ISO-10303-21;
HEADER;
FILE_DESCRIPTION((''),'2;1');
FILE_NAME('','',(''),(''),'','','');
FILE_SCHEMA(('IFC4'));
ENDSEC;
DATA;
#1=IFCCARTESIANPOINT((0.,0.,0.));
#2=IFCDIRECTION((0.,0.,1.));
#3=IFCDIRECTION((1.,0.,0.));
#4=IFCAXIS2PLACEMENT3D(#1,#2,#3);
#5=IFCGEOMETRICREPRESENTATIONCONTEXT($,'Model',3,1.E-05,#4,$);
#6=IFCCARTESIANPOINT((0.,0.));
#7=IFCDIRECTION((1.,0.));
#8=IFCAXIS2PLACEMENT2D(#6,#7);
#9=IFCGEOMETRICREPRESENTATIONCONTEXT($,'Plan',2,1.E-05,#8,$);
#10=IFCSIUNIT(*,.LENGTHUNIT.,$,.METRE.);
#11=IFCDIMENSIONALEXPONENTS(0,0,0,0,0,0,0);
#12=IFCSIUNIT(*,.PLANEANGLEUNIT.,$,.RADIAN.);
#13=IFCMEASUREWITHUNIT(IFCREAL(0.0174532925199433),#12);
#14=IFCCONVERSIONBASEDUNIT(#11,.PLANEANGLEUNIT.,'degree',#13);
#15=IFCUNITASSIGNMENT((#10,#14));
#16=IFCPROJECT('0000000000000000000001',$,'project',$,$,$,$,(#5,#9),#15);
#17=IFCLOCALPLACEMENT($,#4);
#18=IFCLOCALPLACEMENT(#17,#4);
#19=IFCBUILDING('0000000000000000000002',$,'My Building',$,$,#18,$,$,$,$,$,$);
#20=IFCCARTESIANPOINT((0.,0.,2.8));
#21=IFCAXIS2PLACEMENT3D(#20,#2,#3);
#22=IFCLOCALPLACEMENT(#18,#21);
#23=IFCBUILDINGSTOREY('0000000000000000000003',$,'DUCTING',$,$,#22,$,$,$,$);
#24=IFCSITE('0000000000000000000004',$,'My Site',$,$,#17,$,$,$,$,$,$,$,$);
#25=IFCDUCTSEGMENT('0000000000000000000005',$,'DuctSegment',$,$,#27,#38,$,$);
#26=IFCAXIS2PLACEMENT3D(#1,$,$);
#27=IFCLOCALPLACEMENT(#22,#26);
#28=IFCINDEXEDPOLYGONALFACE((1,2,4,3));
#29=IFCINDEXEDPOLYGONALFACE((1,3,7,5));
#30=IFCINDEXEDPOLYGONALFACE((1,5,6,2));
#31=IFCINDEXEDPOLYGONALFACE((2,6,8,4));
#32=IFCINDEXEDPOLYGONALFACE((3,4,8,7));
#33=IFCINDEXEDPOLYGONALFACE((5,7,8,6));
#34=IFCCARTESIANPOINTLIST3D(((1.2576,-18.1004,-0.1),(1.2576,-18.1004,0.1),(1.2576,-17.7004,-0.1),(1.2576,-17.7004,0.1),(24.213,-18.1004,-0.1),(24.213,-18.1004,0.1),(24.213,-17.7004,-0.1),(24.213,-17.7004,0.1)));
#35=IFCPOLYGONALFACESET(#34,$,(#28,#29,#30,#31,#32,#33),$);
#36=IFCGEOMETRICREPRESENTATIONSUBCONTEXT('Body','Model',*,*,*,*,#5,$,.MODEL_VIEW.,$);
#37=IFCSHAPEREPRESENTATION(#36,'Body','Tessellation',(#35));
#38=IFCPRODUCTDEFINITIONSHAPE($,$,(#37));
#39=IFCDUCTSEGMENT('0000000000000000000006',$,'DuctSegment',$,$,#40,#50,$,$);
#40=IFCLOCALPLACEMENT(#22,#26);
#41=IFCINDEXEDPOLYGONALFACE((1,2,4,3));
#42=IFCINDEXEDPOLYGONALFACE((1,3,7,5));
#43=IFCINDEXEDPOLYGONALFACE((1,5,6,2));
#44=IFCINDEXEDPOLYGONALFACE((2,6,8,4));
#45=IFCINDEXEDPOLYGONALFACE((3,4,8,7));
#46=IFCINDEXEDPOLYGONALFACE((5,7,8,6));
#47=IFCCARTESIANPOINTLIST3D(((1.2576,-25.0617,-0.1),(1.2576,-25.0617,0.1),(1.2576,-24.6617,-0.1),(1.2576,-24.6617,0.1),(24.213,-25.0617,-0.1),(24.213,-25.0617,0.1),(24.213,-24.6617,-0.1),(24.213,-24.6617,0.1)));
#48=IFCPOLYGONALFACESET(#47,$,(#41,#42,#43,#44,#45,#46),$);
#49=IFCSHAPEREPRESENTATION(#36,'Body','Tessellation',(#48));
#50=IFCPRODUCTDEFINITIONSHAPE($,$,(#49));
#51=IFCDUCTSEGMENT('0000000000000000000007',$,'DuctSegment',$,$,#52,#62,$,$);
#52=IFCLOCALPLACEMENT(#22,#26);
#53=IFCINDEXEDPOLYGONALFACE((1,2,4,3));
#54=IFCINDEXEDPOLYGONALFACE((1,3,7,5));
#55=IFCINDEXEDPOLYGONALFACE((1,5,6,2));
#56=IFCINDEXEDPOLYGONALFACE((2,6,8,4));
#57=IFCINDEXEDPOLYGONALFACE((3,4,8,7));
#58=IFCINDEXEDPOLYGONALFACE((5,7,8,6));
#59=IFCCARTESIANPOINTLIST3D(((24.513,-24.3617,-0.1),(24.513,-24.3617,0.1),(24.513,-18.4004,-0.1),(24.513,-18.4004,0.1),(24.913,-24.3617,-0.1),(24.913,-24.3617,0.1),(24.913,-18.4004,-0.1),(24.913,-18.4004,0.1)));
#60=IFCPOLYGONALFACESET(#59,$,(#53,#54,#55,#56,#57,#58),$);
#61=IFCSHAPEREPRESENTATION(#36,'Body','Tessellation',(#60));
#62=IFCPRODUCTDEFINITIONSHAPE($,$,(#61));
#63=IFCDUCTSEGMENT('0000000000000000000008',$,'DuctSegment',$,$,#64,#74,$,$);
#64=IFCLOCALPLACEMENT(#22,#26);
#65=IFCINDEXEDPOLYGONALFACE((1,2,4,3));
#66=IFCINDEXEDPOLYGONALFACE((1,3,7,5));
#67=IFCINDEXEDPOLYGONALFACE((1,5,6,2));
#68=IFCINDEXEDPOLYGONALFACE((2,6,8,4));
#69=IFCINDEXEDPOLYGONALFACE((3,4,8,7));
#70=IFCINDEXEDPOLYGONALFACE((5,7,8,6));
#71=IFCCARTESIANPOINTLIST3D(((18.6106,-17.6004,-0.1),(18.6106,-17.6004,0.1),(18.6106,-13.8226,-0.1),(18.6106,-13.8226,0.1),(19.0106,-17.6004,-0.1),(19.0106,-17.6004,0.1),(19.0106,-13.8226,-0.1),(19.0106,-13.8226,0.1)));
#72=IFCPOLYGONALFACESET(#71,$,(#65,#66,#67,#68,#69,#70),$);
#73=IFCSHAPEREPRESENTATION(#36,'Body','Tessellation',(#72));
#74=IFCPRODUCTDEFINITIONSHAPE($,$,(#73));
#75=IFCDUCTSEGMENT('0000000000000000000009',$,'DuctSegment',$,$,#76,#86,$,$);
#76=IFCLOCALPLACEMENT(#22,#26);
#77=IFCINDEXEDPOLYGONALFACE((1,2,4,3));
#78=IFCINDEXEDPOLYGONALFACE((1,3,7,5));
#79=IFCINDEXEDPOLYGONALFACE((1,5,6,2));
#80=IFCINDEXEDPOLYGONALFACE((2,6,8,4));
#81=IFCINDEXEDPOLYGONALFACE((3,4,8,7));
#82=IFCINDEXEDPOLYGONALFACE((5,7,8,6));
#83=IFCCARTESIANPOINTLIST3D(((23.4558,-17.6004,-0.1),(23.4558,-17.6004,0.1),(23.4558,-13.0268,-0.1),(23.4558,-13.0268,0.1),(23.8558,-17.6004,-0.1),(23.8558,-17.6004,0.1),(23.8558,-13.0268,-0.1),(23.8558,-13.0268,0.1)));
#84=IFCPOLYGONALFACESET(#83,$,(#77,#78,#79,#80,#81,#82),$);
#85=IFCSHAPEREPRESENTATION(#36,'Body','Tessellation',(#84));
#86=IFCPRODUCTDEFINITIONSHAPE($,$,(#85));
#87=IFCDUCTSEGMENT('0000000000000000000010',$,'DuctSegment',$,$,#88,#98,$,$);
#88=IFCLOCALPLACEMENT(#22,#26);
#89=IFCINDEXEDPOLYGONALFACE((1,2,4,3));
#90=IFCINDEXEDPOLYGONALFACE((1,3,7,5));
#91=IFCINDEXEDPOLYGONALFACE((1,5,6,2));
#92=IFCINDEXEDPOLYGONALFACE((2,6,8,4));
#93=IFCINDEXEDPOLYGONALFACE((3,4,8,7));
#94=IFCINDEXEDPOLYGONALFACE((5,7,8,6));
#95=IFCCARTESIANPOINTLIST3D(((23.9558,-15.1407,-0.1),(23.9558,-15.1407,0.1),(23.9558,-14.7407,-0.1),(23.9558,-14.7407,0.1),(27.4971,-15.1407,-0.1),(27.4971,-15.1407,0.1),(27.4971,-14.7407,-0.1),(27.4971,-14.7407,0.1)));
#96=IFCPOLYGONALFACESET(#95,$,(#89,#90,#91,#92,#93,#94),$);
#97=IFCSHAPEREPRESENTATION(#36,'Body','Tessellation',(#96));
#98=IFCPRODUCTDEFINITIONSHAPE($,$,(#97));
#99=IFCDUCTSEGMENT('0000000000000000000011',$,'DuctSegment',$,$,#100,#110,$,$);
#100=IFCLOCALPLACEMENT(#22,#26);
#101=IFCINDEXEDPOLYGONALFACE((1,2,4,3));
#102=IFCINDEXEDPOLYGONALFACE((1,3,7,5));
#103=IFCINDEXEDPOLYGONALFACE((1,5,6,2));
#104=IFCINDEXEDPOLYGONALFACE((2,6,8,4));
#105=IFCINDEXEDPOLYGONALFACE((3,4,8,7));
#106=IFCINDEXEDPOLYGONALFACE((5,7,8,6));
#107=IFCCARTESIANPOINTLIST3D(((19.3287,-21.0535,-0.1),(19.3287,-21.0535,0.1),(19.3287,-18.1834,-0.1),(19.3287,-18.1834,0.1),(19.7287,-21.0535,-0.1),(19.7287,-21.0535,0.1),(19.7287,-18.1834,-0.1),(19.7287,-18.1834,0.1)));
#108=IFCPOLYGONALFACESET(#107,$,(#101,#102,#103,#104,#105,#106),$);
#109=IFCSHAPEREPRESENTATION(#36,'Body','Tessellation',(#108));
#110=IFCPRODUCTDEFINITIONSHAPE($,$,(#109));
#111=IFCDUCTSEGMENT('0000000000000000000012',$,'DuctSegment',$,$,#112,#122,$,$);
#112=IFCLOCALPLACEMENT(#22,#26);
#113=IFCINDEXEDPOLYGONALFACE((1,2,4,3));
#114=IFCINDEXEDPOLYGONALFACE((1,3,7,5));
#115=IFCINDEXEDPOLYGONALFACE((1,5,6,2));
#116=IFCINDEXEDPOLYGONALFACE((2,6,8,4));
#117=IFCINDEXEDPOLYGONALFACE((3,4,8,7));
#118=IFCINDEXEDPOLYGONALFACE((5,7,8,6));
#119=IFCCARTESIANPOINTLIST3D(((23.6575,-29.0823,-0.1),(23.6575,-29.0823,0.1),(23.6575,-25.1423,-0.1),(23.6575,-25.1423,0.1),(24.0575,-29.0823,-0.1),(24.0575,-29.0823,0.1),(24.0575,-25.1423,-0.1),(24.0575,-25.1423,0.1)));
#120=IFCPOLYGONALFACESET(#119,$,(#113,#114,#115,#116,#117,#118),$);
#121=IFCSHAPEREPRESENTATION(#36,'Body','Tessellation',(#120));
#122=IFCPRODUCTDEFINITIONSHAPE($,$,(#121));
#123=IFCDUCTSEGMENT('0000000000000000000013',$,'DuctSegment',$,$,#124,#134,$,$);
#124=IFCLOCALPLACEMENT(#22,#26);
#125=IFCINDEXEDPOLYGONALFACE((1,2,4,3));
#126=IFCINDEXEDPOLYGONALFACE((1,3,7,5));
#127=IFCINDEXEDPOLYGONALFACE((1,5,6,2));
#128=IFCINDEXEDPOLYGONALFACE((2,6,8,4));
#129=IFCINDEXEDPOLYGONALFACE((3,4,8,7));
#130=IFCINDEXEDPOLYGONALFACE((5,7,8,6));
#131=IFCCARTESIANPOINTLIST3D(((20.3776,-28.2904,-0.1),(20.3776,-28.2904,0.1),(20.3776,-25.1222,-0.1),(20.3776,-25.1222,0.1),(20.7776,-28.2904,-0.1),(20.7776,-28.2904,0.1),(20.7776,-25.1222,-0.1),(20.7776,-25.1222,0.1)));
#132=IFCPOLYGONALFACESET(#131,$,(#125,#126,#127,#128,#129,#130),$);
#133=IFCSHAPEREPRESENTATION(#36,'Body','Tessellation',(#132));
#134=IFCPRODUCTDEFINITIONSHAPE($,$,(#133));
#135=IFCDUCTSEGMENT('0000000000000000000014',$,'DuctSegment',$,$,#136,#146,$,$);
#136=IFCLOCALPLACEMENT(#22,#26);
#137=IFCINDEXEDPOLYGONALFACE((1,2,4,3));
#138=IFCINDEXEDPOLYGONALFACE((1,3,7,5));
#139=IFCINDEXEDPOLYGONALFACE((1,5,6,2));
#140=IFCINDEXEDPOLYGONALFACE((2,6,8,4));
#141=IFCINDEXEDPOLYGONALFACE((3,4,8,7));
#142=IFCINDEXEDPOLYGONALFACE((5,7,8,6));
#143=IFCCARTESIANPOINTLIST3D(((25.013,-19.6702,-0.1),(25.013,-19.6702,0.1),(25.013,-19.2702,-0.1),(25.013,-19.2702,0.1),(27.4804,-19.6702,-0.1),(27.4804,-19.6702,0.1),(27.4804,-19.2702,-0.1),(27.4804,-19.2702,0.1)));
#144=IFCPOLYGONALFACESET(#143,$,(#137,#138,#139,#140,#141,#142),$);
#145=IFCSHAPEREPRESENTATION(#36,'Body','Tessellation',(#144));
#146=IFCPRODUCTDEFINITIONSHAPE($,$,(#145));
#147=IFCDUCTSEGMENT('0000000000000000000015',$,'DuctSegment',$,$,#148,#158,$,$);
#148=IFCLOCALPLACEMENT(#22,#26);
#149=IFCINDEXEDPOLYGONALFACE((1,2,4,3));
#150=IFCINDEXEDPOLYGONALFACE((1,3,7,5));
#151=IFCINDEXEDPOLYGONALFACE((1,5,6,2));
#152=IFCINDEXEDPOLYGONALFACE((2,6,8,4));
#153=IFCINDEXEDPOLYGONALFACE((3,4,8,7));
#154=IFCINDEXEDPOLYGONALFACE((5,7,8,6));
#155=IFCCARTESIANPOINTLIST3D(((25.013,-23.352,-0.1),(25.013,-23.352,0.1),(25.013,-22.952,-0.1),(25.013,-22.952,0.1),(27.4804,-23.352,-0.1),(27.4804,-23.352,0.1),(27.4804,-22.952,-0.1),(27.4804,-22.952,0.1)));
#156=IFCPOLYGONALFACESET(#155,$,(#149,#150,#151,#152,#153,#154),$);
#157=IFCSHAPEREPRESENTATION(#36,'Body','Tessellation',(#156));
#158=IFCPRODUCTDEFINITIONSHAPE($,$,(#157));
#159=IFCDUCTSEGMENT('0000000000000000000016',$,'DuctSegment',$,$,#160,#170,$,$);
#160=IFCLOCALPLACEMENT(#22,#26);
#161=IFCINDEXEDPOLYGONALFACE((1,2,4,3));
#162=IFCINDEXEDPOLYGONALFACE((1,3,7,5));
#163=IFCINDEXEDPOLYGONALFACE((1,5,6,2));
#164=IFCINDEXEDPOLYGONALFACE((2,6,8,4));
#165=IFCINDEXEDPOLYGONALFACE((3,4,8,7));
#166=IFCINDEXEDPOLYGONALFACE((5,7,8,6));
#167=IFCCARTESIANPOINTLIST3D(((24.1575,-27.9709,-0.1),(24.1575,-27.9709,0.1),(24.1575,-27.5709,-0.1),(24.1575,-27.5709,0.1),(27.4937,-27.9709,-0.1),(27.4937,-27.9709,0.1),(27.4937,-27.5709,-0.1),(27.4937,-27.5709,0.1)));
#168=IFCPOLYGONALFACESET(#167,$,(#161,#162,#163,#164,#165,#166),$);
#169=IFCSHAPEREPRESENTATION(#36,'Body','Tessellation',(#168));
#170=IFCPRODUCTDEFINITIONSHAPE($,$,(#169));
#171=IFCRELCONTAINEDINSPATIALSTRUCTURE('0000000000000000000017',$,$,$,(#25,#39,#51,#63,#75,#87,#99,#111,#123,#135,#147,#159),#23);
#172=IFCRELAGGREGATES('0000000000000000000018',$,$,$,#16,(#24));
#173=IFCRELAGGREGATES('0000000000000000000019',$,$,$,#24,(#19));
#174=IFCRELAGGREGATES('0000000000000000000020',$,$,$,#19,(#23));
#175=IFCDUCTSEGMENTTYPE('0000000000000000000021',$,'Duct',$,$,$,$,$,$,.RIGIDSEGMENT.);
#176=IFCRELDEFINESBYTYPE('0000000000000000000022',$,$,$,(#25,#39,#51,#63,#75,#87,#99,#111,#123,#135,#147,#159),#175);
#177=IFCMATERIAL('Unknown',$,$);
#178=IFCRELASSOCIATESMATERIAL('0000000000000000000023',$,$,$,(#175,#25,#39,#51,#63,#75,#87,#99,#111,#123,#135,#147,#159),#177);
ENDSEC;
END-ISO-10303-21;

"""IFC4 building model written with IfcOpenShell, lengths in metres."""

from ifc_helpers import new_model, entity, si_unit, converted_unit, frame, origin_with_axes, origin_2d_with_axis, place, context, subcontext, project, spatial, rectangle, extrude, material, material_profile, profile_set, profile_usage, type_object, element, save


model = new_model("IFC4")

# Units and contexts
model_context = context("Model", 3, precision=1e-05, world=origin_with_axes())
plan_context = context("Plan", 2, precision=1e-05, world=origin_2d_with_axis())
body_context = subcontext(model_context, "Body", "Model", "MODEL_VIEW")
ifc_project = project(units=[si_unit("LENGTHUNIT", "METRE"), converted_unit("PLANEANGLEUNIT", "degree", entity("IfcReal", 0.0174532925199433), si_unit("PLANEANGLEUNIT", "RADIAN"), dimensions=[0, 0, 0, 0, 0, 0, 0])], contexts=[model_context, plan_context])

# Site, building, storey
site_placement = place(None, origin_with_axes())
site = spatial("IfcSite", under=ifc_project, at=site_placement, Name="My Site")
building_placement = place(site_placement, origin_with_axes())
building = spatial("IfcBuilding", under=site, at=building_placement, Name="My Building")
storey_placement = place(building_placement, frame((0.0, 0.0, 2.8), z_axis=(0.0, 0.0, 1.0), x_axis=(1.0, 0.0, 0.0)))
storey = spatial("IfcBuildingStorey", under=building, at=storey_placement, Name="DUCTING")

# Duct segments
ifc_material = material(Name="Unknown")
ifc_material_profile_1 = material_profile(ifc_material, rectangle(XDim=0.4, YDim=0.2))
ifc_profile_set_1 = profile_set([ifc_material_profile_1])
ifc_profile_usage_1 = profile_usage(ifc_profile_set_1, cardinal=5)
duct_segment_type = type_object("IfcDuctSegmentType", Name="Duct", PredefinedType="RIGIDSEGMENT", material=ifc_profile_set_1)
duct_segment_1_placement = place(storey_placement, frame((24.213, -17.9004, 0.0), z_axis=(-1.0, 0.0, 0.0), x_axis=(0.0, -1.0, 0.0)))
element("IfcDuctSegment", 1, at=duct_segment_1_placement, inside=storey, type_object=duct_segment_type, material=ifc_profile_usage_1, Name="DuctSegment", context=body_context, shape_type="SweptSolid", body=[
    extrude(rectangle(XDim=0.4, YDim=0.2), origin_with_axes(), (0.0, 0.0, 1.0), 22.9554),
])
ifc_profile_usage_2 = profile_usage(ifc_profile_set_1, cardinal=5)
duct_segment_2_placement = place(storey_placement, frame((24.213, -24.8617, 0.0), z_axis=(-1.0, 0.0, 0.0), x_axis=(0.0, -1.0, 0.0)))
element("IfcDuctSegment", 2, at=duct_segment_2_placement, inside=storey, type_object=duct_segment_type, material=ifc_profile_usage_2, Name="DuctSegment", context=body_context, shape_type="SweptSolid", body=[
    extrude(rectangle(XDim=0.4, YDim=0.2), origin_with_axes(), (0.0, 0.0, 1.0), 22.9554),
])
ifc_profile_usage_3 = profile_usage(ifc_profile_set_1, cardinal=5)
duct_segment_3_placement = place(storey_placement, frame((24.713, -24.3617, 0.0), z_axis=(0.0, 1.0, 0.0), x_axis=(-1.0, 0.0, 0.0)))
element("IfcDuctSegment", 3, at=duct_segment_3_placement, inside=storey, type_object=duct_segment_type, material=ifc_profile_usage_3, Name="DuctSegment", context=body_context, shape_type="SweptSolid", body=[
    extrude(rectangle(XDim=0.4, YDim=0.2), origin_with_axes(), (0.0, 0.0, 1.0), 5.9613),
])
ifc_profile_usage_4 = profile_usage(ifc_profile_set_1, cardinal=5)
duct_segment_4_placement = place(storey_placement, frame((18.8106, -17.6004, 0.0), z_axis=(0.0, 1.0, 0.0), x_axis=(-1.0, 0.0, 0.0)))
element("IfcDuctSegment", 4, at=duct_segment_4_placement, inside=storey, type_object=duct_segment_type, material=ifc_profile_usage_4, Name="DuctSegment", context=body_context, shape_type="SweptSolid", body=[
    extrude(rectangle(XDim=0.4, YDim=0.2), origin_with_axes(), (0.0, 0.0, 1.0), 3.7777),
])
ifc_profile_usage_5 = profile_usage(ifc_profile_set_1, cardinal=5)
duct_segment_5_placement = place(storey_placement, frame((23.6558, -17.6004, 0.0), z_axis=(0.0, 1.0, 0.0), x_axis=(-1.0, 0.0, 0.0)))
element("IfcDuctSegment", 5, at=duct_segment_5_placement, inside=storey, type_object=duct_segment_type, material=ifc_profile_usage_5, Name="DuctSegment", context=body_context, shape_type="SweptSolid", body=[
    extrude(rectangle(XDim=0.4, YDim=0.2), origin_with_axes(), (0.0, 0.0, 1.0), 4.5736),
])
ifc_profile_usage_6 = profile_usage(ifc_profile_set_1, cardinal=5)
duct_segment_6_placement = place(storey_placement, frame((23.9558, -14.9407, 0.0), z_axis=(1.0, 0.0, 0.0), x_axis=(0.0, 1.0, 0.0)))
element("IfcDuctSegment", 6, at=duct_segment_6_placement, inside=storey, type_object=duct_segment_type, material=ifc_profile_usage_6, Name="DuctSegment", context=body_context, shape_type="SweptSolid", body=[
    extrude(rectangle(XDim=0.4, YDim=0.2), origin_with_axes(), (0.0, 0.0, 1.0), 3.5414),
])
ifc_profile_usage_7 = profile_usage(ifc_profile_set_1, cardinal=5)
duct_segment_7_placement = place(storey_placement, frame((19.5287, -21.0535, 0.0), z_axis=(-0.000001, 1.0, 0.0), x_axis=(-1.0, -0.000001, 0.0)))
element("IfcDuctSegment", 7, at=duct_segment_7_placement, inside=storey, type_object=duct_segment_type, material=ifc_profile_usage_7, Name="DuctSegment", context=body_context, shape_type="SweptSolid", body=[
    extrude(rectangle(XDim=0.4, YDim=0.2), origin_with_axes(), (0.0, 0.0, 1.0), 2.8701),
])
ifc_profile_usage_8 = profile_usage(ifc_profile_set_1, cardinal=5)
duct_segment_8_placement = place(storey_placement, frame((23.8575, -29.0823, 0.0), z_axis=(0.0, 1.0, 0.0), x_axis=(-1.0, 0.0, 0.0)))
element("IfcDuctSegment", 8, at=duct_segment_8_placement, inside=storey, type_object=duct_segment_type, material=ifc_profile_usage_8, Name="DuctSegment", context=body_context, shape_type="SweptSolid", body=[
    extrude(rectangle(XDim=0.4, YDim=0.2), origin_with_axes(), (0.0, 0.0, 1.0), 3.94),
])
ifc_profile_usage_9 = profile_usage(ifc_profile_set_1, cardinal=5)
duct_segment_9_placement = place(storey_placement, frame((20.5776, -28.2904, 0.0), z_axis=(0.0, 1.0, 0.0), x_axis=(-1.0, 0.0, 0.0)))
element("IfcDuctSegment", 9, at=duct_segment_9_placement, inside=storey, type_object=duct_segment_type, material=ifc_profile_usage_9, Name="DuctSegment", context=body_context, shape_type="SweptSolid", body=[
    extrude(rectangle(XDim=0.4, YDim=0.2), origin_with_axes(), (0.0, 0.0, 1.0), 3.1683),
])
ifc_profile_usage_10 = profile_usage(ifc_profile_set_1, cardinal=5)
duct_segment_10_placement = place(storey_placement, frame((25.013, -19.4702, 0.0), z_axis=(1.0, 0.000001, -0.000001), x_axis=(-0.000001, 1.0, 0.0)))
element("IfcDuctSegment", 10, at=duct_segment_10_placement, inside=storey, type_object=duct_segment_type, material=ifc_profile_usage_10, Name="DuctSegment", context=body_context, shape_type="SweptSolid", body=[
    extrude(rectangle(XDim=0.4, YDim=0.2), origin_with_axes(), (0.0, 0.0, 1.0), 2.4674),
])
ifc_profile_usage_11 = profile_usage(ifc_profile_set_1, cardinal=5)
duct_segment_11_placement = place(storey_placement, frame((25.013, -23.152, 0.0), z_axis=(1.0, 0.000001, -0.000001), x_axis=(-0.000001, 1.0, 0.0)))
element("IfcDuctSegment", 11, at=duct_segment_11_placement, inside=storey, type_object=duct_segment_type, material=ifc_profile_usage_11, Name="DuctSegment", context=body_context, shape_type="SweptSolid", body=[
    extrude(rectangle(XDim=0.4, YDim=0.2), origin_with_axes(), (0.0, 0.0, 1.0), 2.4674),
])
ifc_profile_usage_12 = profile_usage(ifc_profile_set_1, cardinal=5)
duct_segment_12_placement = place(storey_placement, frame((24.1575, -27.7709, 0.0), z_axis=(1.0, 0.0, 0.0), x_axis=(0.0, 1.0, 0.0)))
element("IfcDuctSegment", 12, at=duct_segment_12_placement, inside=storey, type_object=duct_segment_type, material=ifc_profile_usage_12, Name="DuctSegment", context=body_context, shape_type="SweptSolid", body=[
    extrude(rectangle(XDim=0.4, YDim=0.2), origin_with_axes(), (0.0, 0.0, 1.0), 3.3362),
])

save(model, "model.ifc")
